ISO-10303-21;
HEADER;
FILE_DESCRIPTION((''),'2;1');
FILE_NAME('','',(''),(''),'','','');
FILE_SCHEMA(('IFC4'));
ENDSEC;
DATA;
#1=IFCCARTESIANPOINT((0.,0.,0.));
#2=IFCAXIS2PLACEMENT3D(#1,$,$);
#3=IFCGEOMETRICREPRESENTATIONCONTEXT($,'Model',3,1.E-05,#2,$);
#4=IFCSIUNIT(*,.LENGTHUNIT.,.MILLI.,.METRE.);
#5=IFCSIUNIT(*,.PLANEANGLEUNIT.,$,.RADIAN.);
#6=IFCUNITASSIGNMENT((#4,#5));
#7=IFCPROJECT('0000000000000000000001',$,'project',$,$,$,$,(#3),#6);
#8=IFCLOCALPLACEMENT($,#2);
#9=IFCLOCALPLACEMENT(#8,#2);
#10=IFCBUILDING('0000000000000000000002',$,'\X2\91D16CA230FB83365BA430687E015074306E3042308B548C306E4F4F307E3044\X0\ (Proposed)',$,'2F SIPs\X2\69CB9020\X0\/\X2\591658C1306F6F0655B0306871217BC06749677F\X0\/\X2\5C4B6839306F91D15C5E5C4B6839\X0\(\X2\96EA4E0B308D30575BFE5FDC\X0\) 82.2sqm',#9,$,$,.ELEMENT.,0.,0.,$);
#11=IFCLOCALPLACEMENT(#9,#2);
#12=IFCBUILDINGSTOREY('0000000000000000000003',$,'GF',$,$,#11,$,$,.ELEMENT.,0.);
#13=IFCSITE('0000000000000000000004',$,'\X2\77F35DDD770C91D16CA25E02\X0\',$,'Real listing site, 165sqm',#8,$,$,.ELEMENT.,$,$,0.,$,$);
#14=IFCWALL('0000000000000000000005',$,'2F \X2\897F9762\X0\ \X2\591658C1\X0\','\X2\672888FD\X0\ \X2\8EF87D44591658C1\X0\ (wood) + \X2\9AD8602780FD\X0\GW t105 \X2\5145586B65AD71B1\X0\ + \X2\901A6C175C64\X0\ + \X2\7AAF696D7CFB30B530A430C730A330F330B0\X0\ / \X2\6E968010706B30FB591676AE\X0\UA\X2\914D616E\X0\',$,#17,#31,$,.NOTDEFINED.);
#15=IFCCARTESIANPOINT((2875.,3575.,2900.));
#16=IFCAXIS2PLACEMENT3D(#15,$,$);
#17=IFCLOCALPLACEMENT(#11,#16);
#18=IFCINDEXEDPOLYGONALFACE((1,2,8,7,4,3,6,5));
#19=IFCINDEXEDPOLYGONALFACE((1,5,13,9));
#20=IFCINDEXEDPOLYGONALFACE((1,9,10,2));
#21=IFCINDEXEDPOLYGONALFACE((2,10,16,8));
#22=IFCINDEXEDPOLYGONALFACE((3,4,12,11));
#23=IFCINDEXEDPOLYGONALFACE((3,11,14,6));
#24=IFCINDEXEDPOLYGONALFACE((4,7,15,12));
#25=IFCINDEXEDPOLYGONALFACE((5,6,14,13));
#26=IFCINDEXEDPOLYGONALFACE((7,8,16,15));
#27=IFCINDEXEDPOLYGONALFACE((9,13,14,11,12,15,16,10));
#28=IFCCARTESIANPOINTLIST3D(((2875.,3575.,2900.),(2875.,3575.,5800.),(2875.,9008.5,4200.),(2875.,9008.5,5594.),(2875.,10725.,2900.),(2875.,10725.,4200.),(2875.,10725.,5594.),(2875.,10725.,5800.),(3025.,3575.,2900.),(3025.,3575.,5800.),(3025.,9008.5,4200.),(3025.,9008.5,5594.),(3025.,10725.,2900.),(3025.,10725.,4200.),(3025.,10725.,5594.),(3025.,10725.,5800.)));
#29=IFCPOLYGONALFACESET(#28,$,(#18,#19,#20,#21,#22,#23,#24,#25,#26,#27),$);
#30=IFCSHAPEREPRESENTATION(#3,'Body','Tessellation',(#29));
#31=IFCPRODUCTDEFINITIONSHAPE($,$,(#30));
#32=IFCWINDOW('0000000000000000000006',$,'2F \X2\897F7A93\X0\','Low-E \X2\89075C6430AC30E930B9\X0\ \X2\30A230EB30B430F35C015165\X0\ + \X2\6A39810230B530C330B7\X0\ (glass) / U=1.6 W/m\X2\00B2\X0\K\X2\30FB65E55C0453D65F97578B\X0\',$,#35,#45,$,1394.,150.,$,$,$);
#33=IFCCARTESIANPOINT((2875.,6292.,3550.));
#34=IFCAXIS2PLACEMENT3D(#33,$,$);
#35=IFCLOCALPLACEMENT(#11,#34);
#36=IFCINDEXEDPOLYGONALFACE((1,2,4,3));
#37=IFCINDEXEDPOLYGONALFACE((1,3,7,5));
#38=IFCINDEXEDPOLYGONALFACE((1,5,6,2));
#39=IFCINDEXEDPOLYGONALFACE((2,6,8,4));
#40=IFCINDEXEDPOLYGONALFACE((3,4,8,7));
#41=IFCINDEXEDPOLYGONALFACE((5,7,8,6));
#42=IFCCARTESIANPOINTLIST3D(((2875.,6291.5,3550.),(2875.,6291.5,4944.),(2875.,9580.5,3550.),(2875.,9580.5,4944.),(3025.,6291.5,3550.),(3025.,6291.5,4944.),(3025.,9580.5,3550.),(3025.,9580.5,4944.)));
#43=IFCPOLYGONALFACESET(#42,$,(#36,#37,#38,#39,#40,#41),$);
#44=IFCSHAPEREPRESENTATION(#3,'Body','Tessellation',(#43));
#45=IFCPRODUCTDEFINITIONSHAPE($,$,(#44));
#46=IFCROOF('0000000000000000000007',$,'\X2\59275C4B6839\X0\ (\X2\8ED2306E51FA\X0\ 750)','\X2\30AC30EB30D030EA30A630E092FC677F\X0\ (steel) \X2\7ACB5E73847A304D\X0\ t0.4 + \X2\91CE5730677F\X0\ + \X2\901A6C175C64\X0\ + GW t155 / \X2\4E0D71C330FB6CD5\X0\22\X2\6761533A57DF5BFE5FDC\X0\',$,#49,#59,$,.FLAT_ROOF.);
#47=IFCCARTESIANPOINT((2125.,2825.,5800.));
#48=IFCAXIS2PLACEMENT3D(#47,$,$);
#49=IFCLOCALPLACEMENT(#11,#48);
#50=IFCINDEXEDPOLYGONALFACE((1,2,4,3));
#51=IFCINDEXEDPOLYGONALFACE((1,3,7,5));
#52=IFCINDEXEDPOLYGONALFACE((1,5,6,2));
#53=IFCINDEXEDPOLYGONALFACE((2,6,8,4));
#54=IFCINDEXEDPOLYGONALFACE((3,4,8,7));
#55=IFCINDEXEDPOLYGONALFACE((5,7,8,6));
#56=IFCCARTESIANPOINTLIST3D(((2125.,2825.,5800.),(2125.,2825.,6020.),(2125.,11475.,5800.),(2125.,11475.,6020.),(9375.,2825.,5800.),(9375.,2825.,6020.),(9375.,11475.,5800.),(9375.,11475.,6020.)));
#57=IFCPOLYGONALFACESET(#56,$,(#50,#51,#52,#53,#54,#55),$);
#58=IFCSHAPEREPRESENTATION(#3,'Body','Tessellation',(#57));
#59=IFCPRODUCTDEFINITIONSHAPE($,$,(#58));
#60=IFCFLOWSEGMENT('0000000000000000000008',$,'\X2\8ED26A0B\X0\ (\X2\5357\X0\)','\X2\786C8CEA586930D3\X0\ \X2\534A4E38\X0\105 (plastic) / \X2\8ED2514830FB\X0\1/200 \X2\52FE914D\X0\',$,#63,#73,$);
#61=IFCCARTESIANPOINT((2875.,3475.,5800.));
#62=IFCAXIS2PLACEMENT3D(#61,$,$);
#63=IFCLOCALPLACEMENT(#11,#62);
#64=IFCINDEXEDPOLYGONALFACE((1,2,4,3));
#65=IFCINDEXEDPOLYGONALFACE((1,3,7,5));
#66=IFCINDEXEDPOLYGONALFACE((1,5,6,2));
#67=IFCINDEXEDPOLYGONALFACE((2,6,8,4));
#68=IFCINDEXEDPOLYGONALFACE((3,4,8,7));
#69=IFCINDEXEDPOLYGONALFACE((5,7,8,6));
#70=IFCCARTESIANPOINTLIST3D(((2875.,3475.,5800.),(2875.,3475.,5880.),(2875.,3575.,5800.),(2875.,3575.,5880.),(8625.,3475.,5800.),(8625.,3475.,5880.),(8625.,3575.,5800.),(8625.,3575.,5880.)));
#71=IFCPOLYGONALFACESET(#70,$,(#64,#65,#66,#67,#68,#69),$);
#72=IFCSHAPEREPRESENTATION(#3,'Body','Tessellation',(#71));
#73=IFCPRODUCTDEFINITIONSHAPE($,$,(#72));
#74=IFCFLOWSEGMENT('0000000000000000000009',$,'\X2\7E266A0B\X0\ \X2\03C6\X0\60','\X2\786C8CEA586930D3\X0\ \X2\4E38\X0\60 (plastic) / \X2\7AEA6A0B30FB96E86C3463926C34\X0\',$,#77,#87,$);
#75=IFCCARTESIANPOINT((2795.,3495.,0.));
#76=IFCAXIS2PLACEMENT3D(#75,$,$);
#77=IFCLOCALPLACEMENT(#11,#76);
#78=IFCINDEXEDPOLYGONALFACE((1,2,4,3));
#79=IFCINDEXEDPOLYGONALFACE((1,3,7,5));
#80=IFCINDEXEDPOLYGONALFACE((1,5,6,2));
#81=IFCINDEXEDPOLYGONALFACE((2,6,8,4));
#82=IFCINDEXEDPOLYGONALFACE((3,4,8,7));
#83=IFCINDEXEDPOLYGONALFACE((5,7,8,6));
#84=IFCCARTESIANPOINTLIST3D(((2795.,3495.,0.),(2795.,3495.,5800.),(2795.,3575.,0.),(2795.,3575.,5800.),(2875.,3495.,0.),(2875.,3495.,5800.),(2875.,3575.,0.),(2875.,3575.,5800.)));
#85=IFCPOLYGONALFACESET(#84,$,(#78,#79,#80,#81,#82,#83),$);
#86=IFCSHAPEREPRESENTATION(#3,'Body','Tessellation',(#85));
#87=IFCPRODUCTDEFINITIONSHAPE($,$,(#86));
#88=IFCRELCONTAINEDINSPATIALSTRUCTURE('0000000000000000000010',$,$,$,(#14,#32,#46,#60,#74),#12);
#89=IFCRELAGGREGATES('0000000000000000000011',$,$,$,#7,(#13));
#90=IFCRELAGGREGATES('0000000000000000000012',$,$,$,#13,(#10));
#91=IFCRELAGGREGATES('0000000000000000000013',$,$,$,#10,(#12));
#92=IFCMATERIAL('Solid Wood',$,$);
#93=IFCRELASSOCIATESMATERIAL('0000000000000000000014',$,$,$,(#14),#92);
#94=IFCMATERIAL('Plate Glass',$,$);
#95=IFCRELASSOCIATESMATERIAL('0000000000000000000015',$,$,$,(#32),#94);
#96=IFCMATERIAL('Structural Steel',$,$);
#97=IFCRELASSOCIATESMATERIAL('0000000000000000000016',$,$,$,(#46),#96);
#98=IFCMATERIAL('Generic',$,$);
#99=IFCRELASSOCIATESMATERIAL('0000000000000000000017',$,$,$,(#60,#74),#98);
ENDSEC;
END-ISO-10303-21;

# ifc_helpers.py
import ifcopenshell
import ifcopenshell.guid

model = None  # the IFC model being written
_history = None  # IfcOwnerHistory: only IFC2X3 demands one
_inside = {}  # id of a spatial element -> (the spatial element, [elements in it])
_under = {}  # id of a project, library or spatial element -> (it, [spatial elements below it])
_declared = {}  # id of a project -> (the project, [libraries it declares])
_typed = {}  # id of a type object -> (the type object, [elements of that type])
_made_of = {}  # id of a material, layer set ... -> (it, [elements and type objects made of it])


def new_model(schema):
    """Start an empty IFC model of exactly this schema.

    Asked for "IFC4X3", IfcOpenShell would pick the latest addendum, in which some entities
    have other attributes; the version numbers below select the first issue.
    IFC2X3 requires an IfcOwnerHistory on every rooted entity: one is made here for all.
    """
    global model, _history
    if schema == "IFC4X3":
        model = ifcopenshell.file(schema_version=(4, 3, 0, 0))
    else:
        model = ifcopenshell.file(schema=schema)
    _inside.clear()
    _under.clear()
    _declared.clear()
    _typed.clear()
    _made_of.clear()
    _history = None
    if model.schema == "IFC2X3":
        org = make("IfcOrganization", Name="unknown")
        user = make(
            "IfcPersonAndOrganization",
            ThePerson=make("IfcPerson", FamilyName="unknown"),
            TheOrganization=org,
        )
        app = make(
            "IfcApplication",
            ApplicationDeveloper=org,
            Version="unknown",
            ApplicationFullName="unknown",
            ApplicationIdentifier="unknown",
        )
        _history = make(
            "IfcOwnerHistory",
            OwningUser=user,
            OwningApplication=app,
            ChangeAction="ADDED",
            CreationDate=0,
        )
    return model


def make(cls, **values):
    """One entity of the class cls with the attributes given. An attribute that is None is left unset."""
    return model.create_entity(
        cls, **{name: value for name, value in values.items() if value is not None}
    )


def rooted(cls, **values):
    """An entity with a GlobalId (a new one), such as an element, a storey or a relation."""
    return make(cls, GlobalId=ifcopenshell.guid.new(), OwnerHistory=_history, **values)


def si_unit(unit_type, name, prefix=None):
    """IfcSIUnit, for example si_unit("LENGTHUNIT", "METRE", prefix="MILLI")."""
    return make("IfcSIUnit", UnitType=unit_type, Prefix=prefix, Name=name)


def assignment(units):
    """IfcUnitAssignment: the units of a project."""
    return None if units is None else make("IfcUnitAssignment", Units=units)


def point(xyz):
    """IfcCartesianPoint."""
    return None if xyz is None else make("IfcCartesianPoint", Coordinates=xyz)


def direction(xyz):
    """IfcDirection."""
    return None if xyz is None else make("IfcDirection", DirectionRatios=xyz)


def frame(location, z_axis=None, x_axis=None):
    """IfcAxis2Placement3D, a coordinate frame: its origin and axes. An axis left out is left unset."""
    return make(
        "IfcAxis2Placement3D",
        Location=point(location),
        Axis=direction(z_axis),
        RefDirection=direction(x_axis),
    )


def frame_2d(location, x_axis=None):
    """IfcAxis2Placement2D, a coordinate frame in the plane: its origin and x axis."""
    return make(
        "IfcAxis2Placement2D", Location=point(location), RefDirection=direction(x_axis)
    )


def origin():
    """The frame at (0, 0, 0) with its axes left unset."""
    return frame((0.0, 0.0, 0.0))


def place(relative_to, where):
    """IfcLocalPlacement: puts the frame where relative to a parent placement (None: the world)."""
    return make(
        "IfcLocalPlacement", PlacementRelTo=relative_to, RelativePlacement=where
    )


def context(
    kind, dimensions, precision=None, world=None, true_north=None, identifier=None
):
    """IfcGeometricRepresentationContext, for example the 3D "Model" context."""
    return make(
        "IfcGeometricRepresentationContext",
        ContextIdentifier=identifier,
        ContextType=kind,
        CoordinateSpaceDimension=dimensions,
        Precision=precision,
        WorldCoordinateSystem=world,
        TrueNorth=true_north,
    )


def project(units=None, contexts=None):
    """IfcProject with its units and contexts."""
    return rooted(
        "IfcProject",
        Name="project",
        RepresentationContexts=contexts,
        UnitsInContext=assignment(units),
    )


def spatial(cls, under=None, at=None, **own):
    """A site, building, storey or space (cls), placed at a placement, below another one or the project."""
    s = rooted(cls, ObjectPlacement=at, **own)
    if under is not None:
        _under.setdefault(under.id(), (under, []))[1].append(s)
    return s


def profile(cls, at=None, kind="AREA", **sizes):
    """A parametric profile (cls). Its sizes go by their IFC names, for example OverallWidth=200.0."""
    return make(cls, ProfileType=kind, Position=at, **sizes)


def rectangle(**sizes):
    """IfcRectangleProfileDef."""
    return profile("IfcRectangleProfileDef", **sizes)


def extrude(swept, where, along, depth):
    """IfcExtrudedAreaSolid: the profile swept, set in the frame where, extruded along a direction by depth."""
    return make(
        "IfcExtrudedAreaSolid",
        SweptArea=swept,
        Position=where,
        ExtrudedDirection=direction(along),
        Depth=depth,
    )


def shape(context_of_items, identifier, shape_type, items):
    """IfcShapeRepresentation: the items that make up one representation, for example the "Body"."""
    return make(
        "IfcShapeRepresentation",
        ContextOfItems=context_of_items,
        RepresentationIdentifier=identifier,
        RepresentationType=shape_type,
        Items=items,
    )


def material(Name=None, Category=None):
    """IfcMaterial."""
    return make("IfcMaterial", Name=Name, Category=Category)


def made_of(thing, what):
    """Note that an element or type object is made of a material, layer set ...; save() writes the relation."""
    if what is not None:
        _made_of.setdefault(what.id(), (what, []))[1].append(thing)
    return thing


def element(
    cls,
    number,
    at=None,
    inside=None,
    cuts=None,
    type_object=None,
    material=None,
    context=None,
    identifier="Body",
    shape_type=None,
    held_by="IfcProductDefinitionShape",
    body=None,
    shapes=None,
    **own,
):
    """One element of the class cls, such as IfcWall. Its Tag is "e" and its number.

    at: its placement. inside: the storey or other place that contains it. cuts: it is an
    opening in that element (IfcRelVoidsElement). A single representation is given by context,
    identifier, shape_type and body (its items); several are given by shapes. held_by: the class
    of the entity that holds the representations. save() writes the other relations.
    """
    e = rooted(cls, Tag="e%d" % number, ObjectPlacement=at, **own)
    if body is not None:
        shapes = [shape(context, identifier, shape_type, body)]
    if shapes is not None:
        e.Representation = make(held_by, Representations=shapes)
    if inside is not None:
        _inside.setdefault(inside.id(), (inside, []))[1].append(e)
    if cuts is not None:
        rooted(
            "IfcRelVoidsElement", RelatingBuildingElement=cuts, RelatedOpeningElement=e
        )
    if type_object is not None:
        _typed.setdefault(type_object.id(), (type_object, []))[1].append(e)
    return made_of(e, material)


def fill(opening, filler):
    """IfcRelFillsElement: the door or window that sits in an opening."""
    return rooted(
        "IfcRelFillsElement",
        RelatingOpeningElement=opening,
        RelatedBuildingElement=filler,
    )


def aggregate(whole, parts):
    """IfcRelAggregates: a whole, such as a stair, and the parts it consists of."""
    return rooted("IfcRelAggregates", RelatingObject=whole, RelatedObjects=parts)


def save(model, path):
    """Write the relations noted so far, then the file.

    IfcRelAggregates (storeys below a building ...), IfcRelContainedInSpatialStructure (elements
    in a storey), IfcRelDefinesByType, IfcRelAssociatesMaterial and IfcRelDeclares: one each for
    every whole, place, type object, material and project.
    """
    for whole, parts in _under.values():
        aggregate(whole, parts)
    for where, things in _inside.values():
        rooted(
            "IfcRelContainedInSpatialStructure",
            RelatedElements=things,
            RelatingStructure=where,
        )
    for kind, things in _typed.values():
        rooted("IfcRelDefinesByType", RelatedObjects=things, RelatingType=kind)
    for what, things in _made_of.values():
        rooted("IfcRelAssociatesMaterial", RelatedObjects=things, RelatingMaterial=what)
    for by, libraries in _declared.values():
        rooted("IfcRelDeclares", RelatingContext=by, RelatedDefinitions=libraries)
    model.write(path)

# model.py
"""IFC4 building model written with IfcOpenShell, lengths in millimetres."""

from ifc_helpers import new_model, si_unit, frame, frame_2d, origin, place, context, project, spatial, rectangle, extrude, material, element, fill, save


model = new_model("IFC4")

# Units and contexts
model_context = context("Model", 3, precision=1e-05, world=origin())
ifc_project = project(units=[si_unit("LENGTHUNIT", "METRE", prefix="MILLI"), si_unit("PLANEANGLEUNIT", "RADIAN")], contexts=[model_context])

# Site, building, storey
site_placement = place(None, origin())
site = spatial("IfcSite", under=ifc_project, at=site_placement, Name="石川県金沢市", ObjectType="Real listing site, 165sqm", CompositionType="ELEMENT", RefElevation=0.0)
building_placement = place(site_placement, origin())
building = spatial("IfcBuilding", under=site, at=building_placement, Name="金沢・茶室と縁側のある和の住まい (Proposed)", ObjectType="2F SIPs構造/外壁は漆喰と無節杉板/屋根は金属屋根(雪下ろし対応) 82.2sqm", CompositionType="ELEMENT", ElevationOfRefHeight=0.0, ElevationOfTerrain=0.0)
storey_placement = place(building_placement, origin())
storey = spatial("IfcBuildingStorey", under=building, at=storey_placement, Name="GF", CompositionType="ELEMENT", Elevation=0.0)

# Shared definitions
ifc_material_1 = material(Name="Solid Wood")

# Shared definitions
ifc_material_2 = material(Name="Plate Glass")

# Wall, opening, window
wall_1_placement = place(storey_placement, frame((2875.0, 3575.0, 2900.0)))
wall_1 = element("IfcWall", 1, at=wall_1_placement, inside=storey, material=ifc_material_1, Name="2F 西面 外壁", Description="木製 軸組外壁 (wood) + 高性能GW t105 充填断熱 + 通気層 + 窯業系サイディング / 準耐火・外皮UA配慮", PredefinedType="NOTDEFINED", context=model_context, shape_type="SweptSolid", body=[
    extrude(rectangle(XDim=150.0, YDim=7150.0, at=frame_2d((75.0, 3575.0))), frame((2875.0, 3575.0, 2900.0)), (0.0, 0.0, 1.0), 2900.0),
])
opening_1_placement = place(storey_placement, frame((2875.0, 6292.0, 3550.0)))
opening_1 = element("IfcOpeningElement", 2, at=opening_1_placement, cuts=wall_1, PredefinedType="NOTDEFINED", context=model_context, shape_type="SweptSolid", body=[
    extrude(rectangle(XDim=150.0, YDim=3289.0, at=frame_2d((75.0, 1644.0))), frame((2875.0, 6292.0, 3550.0)), (0.0, 0.0, 1.0), 1394.0),
])
window_1_placement = place(storey_placement, frame((2875.0, 6292.0, 3550.0)))
window_1 = element("IfcWindow", 3, at=window_1_placement, inside=storey, material=ifc_material_2, Name="2F 西窓", Description="Low-E 複層ガラス アルゴン封入 + 樹脂サッシ (glass) / U=1.6 W/m²K・日射取得型", OverallHeight=1394.0, OverallWidth=150.0, context=model_context, shape_type="SweptSolid", body=[
    extrude(rectangle(XDim=150.0, YDim=3289.0, at=frame_2d((75.0, 1644.0))), frame((2875.0, 6292.0, 3550.0)), (0.0, 0.0, 1.0), 1394.0),
])
fill(opening_1, window_1)

# Roof
ifc_material_3 = material(Name="Structural Steel")
roof_placement = place(storey_placement, frame((2125.0, 2825.0, 5800.0)))
element("IfcRoof", 4, at=roof_placement, inside=storey, material=ifc_material_3, Name="大屋根 (軒の出 750)", Description="ガルバリウム鋼板 (steel) 立平葺き t0.4 + 野地板 + 通気層 + GW t155 / 不燃・法22条区域対応", PredefinedType="FLAT_ROOF", context=model_context, shape_type="SweptSolid", body=[
    extrude(rectangle(XDim=7250.0, YDim=8650.0, at=frame_2d((3625.0, 4325.0))), frame((2125.0, 2825.0, 5800.0)), (0.0, 0.0, 1.0), 220.0),
])

# Flow segments
ifc_material_4 = material(Name="Generic")
flow_segment_1_placement = place(storey_placement, frame((2875.0, 3475.0, 5800.0)))
element("IfcFlowSegment", 5, at=flow_segment_1_placement, inside=storey, material=ifc_material_4, Name="軒樋 (南)", Description="硬質塩ビ 半丸105 (plastic) / 軒先・1/200 勾配", context=model_context, shape_type="SweptSolid", body=[
    extrude(rectangle(XDim=5750.0, YDim=100.0, at=frame_2d((2875.0, 50.0))), frame((2875.0, 3475.0, 5800.0)), (0.0, 0.0, 1.0), 80.0),
])
flow_segment_2_placement = place(storey_placement, frame((2795.0, 3495.0, 0.0)))
element("IfcFlowSegment", 6, at=flow_segment_2_placement, inside=storey, material=ifc_material_4, Name="縦樋 φ60", Description="硬質塩ビ 丸60 (plastic) / 竪樋・雨水排水", context=model_context, shape_type="SweptSolid", body=[
    extrude(rectangle(XDim=80.0, YDim=80.0, at=frame_2d((40.0, 40.0))), frame((2795.0, 3495.0, 0.0)), (0.0, 0.0, 1.0), 5800.0),
])

save(model, "model.ifc")
